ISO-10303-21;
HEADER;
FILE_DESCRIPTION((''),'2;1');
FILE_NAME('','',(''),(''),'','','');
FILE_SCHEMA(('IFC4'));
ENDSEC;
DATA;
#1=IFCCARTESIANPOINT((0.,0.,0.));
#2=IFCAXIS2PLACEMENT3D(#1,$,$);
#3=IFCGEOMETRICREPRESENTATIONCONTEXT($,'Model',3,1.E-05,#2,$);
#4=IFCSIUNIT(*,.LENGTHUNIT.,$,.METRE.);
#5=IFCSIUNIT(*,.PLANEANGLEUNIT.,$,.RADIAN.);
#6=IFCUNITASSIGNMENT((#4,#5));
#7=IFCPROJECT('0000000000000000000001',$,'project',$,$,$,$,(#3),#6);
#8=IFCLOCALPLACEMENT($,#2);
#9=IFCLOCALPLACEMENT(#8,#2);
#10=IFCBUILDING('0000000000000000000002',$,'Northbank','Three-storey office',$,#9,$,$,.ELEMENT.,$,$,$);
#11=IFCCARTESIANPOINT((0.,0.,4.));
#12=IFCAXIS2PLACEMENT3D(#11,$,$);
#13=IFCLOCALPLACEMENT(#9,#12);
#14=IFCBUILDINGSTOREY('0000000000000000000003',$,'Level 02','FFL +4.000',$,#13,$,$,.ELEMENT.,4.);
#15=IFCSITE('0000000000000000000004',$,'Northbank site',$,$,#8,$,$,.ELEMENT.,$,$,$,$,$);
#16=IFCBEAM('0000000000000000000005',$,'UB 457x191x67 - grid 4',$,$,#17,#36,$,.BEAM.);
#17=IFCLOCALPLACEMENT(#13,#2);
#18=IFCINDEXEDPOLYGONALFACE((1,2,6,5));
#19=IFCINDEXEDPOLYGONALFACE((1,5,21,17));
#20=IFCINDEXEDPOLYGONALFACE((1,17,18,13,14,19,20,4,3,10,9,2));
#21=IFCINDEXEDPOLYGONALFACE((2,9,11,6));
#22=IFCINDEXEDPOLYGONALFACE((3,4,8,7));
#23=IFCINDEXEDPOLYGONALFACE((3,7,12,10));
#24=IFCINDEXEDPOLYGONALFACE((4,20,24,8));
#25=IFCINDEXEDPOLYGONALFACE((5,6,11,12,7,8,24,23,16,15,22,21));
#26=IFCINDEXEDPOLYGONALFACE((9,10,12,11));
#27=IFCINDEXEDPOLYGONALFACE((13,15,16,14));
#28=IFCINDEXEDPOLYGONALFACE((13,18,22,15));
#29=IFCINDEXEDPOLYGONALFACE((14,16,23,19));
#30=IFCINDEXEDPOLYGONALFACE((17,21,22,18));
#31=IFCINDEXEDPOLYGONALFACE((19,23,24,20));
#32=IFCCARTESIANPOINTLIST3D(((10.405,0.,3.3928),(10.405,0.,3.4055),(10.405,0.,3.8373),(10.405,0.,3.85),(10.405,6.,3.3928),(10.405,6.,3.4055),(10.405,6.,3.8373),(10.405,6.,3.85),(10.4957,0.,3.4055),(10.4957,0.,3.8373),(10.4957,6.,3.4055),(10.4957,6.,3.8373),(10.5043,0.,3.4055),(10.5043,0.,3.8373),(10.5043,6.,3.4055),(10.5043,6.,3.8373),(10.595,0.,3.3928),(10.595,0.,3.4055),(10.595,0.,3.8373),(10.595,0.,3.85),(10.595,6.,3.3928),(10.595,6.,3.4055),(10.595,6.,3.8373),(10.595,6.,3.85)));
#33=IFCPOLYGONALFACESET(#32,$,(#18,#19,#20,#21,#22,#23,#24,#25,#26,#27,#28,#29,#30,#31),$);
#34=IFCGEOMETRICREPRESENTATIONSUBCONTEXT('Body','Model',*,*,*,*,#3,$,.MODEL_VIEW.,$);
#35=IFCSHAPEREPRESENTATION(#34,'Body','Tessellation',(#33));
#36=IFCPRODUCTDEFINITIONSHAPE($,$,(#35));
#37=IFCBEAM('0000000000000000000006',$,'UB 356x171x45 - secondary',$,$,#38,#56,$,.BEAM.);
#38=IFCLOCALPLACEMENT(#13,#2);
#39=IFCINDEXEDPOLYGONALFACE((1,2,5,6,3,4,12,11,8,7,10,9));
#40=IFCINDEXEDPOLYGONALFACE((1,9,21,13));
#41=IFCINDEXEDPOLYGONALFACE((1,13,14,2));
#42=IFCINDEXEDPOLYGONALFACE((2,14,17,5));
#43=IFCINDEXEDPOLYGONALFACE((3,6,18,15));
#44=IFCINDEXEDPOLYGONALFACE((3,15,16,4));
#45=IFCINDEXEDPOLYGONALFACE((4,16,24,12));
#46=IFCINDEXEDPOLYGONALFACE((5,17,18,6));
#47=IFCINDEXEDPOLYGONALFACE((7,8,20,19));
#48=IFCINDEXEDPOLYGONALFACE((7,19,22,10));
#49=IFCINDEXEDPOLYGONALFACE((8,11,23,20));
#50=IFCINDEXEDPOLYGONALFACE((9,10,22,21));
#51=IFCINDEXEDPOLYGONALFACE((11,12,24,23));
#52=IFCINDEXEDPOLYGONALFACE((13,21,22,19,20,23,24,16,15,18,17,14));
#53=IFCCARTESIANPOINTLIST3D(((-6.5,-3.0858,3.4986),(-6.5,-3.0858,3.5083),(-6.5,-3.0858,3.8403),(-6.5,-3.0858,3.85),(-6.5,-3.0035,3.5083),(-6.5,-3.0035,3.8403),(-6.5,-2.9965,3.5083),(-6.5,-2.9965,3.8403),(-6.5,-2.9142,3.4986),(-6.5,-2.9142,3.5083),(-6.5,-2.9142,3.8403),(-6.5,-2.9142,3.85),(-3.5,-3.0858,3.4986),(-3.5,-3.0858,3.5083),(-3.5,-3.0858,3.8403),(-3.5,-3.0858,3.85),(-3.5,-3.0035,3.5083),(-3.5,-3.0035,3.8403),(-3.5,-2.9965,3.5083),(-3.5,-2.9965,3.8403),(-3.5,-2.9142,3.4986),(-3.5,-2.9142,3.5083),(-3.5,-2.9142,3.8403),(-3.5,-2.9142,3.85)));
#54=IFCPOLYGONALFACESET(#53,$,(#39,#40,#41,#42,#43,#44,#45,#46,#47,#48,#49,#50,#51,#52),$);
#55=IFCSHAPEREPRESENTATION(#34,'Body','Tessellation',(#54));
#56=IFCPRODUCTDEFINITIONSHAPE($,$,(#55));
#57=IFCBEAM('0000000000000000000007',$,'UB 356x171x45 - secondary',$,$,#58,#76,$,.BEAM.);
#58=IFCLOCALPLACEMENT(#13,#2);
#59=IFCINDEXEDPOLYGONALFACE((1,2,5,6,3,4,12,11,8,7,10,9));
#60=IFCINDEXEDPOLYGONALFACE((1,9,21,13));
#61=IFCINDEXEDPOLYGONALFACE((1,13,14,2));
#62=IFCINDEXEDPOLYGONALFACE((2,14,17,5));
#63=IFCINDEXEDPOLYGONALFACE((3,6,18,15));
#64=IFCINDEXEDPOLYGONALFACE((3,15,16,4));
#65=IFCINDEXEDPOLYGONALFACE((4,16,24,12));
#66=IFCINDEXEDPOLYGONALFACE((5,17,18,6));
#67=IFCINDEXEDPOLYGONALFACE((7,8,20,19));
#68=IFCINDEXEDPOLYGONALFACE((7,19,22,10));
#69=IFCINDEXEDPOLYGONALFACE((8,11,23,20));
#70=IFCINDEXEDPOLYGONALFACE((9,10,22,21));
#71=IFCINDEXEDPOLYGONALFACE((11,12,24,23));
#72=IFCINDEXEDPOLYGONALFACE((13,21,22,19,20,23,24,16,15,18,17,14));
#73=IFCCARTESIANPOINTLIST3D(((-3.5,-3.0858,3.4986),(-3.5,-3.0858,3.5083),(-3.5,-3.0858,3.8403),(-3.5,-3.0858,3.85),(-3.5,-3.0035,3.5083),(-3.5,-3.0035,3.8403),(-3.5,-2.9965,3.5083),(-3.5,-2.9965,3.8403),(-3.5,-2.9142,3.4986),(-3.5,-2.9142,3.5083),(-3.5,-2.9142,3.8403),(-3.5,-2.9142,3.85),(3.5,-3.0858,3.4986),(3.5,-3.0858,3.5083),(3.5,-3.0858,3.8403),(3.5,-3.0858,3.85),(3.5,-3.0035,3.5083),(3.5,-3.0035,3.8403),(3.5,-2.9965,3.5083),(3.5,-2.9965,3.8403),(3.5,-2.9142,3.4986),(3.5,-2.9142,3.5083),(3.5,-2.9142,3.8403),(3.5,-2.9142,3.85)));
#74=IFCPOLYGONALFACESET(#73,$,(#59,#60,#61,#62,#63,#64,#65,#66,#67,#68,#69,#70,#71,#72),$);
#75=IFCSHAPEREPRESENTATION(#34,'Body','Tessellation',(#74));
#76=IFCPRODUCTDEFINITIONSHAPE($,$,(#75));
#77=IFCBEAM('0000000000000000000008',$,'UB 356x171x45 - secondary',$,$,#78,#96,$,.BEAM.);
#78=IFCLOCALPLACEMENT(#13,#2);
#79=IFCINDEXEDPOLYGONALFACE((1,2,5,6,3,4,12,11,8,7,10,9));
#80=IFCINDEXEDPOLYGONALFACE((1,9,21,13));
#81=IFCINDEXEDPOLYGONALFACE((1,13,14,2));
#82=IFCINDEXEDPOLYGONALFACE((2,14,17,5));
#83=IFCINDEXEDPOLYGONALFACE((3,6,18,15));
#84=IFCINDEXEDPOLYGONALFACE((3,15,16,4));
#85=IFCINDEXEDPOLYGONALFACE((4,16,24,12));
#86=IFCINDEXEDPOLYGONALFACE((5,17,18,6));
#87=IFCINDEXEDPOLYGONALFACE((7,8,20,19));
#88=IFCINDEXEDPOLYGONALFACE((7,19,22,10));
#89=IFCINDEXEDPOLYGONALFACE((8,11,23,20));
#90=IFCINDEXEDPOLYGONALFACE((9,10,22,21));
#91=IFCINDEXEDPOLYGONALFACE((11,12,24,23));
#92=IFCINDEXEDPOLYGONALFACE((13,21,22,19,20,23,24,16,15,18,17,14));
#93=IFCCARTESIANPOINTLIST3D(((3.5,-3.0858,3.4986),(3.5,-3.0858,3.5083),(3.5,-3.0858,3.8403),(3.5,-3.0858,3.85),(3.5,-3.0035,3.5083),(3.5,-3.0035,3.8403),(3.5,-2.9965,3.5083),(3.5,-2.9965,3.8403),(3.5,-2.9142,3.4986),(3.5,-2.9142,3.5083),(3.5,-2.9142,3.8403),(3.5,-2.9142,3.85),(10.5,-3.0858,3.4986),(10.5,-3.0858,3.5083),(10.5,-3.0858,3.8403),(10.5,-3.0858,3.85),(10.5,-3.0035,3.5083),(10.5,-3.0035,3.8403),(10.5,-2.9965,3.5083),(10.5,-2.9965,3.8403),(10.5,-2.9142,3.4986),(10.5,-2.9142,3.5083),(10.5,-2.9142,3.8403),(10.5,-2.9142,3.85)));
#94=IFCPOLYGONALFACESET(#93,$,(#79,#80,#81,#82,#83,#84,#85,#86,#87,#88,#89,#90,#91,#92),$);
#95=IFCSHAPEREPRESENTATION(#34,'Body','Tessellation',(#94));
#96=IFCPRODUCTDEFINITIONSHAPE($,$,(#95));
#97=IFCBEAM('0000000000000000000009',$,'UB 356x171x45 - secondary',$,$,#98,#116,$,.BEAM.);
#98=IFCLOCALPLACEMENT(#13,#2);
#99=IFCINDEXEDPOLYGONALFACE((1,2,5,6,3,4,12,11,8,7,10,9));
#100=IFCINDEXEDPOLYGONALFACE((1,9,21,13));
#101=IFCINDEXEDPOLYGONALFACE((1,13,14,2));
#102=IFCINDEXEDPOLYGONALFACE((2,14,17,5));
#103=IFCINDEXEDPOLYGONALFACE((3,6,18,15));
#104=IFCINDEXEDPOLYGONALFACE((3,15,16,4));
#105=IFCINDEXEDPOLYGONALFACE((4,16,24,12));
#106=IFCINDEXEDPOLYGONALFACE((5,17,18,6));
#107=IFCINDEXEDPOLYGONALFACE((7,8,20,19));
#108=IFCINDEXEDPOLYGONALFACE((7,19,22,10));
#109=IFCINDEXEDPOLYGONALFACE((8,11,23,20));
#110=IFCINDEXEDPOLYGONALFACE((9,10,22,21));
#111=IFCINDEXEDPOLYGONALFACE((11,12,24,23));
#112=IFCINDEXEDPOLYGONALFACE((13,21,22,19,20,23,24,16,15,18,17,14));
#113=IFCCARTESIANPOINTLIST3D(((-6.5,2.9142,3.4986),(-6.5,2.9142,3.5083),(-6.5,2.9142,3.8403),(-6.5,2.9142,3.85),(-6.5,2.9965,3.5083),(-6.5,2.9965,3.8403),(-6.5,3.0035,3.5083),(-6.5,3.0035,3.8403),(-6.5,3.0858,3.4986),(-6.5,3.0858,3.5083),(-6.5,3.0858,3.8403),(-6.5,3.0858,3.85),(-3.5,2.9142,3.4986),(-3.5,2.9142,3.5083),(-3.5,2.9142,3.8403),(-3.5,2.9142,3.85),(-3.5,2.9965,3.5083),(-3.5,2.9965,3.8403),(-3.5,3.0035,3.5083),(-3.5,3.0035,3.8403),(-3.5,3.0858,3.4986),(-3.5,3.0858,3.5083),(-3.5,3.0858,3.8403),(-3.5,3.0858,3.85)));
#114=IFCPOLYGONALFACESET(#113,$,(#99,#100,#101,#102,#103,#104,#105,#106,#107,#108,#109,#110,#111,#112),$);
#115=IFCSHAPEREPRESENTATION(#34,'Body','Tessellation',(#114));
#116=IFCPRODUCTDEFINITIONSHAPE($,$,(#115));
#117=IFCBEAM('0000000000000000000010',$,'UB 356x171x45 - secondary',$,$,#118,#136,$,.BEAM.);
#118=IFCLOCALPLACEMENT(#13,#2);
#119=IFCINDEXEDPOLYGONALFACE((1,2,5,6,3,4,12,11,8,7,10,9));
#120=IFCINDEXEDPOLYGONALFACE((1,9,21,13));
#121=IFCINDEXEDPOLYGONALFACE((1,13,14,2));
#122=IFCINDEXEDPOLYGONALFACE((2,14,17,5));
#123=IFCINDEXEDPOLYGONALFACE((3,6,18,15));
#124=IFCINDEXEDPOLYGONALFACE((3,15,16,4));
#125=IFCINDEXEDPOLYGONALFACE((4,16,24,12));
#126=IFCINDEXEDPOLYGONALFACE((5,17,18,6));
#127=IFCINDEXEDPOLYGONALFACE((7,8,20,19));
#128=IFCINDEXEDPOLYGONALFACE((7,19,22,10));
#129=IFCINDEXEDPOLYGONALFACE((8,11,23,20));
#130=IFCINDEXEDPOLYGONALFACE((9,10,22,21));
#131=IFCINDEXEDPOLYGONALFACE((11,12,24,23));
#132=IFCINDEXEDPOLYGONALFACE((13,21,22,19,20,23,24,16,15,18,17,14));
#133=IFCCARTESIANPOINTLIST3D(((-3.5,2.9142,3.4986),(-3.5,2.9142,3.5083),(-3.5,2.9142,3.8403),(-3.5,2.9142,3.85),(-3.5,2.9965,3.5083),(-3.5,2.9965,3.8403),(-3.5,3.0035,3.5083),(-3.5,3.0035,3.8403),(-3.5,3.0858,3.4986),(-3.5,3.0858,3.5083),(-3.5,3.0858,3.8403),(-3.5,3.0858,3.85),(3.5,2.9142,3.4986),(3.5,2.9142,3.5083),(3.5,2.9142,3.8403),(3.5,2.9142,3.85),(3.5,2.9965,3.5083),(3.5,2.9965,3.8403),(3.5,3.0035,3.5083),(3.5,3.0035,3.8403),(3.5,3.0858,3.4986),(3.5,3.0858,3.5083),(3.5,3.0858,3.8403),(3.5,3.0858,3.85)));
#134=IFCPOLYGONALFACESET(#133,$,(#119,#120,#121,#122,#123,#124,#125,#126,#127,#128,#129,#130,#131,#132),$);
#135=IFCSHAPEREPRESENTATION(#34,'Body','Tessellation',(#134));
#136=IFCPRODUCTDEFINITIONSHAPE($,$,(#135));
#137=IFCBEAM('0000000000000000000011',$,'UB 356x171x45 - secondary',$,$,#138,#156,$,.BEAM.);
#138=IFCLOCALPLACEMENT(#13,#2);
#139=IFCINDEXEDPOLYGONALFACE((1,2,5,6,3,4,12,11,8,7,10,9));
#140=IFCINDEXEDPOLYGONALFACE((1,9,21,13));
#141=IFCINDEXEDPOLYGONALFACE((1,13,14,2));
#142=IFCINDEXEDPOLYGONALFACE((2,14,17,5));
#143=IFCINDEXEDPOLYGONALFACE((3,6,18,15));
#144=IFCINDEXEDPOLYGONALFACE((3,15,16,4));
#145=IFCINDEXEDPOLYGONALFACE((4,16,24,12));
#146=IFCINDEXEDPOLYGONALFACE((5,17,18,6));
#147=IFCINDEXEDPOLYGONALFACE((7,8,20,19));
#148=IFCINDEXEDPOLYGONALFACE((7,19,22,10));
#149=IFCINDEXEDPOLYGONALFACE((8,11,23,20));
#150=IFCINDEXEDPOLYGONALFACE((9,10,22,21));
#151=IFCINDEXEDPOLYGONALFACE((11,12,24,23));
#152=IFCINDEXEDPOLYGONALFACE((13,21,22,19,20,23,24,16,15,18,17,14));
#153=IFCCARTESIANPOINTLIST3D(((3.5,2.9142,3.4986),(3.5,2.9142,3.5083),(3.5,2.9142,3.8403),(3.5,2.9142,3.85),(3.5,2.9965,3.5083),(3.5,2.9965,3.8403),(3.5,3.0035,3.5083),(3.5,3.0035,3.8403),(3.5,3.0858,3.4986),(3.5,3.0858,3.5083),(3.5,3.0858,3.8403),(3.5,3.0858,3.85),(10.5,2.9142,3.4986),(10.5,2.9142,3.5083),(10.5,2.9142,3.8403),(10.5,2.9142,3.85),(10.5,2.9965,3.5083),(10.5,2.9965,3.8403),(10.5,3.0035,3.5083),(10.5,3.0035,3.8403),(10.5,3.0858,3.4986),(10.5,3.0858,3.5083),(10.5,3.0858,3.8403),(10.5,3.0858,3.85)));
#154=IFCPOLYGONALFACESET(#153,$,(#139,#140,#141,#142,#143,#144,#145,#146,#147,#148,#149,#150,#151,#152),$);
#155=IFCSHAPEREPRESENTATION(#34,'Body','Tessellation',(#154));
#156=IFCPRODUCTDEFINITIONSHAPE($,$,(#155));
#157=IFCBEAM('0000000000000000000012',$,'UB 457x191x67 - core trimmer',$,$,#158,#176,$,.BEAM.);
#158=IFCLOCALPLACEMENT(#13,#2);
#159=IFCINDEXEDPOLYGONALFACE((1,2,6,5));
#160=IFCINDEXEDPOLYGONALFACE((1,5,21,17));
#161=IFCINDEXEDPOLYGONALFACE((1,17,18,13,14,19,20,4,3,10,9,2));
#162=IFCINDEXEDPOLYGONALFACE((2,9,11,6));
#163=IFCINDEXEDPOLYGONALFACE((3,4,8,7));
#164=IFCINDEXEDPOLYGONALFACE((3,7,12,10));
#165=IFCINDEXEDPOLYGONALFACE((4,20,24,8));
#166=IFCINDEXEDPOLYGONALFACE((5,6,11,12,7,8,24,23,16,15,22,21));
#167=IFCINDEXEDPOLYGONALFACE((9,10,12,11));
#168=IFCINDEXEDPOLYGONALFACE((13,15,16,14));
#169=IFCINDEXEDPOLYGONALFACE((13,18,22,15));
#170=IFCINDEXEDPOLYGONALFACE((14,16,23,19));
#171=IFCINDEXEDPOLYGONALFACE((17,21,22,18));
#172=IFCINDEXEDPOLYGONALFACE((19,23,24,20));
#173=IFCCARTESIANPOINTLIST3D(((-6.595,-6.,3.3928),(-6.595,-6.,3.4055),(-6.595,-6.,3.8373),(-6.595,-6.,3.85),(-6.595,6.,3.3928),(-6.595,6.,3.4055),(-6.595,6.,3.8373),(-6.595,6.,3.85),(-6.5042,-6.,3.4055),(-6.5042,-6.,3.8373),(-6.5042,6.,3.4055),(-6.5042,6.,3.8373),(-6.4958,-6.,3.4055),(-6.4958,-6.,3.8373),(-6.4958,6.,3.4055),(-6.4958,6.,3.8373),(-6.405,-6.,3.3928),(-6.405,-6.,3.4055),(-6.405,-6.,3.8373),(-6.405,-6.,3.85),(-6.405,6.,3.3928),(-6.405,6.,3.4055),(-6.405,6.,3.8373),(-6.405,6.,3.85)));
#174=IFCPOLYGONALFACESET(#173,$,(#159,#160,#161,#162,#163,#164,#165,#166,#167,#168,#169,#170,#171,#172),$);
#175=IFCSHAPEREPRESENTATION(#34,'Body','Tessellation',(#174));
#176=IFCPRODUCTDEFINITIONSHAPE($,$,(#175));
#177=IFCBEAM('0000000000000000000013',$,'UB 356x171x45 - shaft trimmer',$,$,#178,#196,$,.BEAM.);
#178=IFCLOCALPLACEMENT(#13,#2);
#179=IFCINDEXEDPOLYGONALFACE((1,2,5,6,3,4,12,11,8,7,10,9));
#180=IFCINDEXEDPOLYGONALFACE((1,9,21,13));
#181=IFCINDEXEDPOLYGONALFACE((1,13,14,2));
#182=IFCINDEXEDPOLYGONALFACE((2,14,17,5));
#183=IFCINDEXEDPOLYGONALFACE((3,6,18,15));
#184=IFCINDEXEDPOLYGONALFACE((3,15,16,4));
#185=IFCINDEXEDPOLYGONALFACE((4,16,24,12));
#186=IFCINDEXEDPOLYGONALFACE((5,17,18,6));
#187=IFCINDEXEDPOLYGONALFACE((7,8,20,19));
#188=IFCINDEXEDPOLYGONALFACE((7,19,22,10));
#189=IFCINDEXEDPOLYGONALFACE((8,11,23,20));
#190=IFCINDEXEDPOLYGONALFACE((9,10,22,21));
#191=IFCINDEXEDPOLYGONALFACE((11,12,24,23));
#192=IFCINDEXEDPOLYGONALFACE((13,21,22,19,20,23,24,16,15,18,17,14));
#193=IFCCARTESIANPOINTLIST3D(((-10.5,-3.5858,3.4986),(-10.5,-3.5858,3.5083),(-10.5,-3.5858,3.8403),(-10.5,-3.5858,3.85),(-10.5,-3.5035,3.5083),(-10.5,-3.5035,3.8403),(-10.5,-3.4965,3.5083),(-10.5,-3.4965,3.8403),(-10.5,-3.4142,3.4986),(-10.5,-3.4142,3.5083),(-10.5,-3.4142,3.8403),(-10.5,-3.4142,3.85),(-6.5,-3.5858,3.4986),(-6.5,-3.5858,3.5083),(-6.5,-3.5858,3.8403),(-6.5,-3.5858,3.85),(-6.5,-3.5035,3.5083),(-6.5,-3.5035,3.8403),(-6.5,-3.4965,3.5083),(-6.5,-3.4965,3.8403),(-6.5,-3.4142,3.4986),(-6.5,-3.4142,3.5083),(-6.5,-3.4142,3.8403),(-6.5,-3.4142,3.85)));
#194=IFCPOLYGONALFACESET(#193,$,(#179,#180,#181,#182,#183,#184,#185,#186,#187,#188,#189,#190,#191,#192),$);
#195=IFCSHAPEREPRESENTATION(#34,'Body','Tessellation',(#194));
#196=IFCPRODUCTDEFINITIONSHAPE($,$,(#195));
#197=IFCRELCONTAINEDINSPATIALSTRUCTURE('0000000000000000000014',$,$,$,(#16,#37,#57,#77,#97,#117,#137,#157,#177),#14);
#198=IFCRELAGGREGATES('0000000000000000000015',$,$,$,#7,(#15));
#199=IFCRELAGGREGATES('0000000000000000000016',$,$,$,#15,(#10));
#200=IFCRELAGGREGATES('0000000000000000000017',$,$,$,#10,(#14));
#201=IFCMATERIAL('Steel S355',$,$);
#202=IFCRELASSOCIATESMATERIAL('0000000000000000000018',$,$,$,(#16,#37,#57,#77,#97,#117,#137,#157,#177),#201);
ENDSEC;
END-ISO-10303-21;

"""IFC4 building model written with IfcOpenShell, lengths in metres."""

from ifc_helpers import new_model, si_unit, frame, origin, place, context, subcontext, project, spatial, i_section, extrude, material, element, save


model = new_model("IFC4")

# Units and contexts
model_context = context("Model", 3, precision=1e-05, world=origin())
body_context = subcontext(model_context, "Body", "Model", "MODEL_VIEW")
ifc_project = project(units=[si_unit("LENGTHUNIT", "METRE"), si_unit("PLANEANGLEUNIT", "RADIAN")], contexts=[model_context])

# Site, building, storey
site_placement = place(None, origin())
site = spatial("IfcSite", under=ifc_project, at=site_placement, Name="Northbank site", CompositionType="ELEMENT")
building_placement = place(site_placement, origin())
building = spatial("IfcBuilding", under=site, at=building_placement, Name="Northbank", Description="Three-storey office", CompositionType="ELEMENT")
storey_placement = place(building_placement, frame((0.0, 0.0, 4.0)))
storey = spatial("IfcBuildingStorey", under=building, at=storey_placement, Name="Level 02", Description="FFL +4.000", CompositionType="ELEMENT", Elevation=4.0)

# Beams
ifc_material_1 = material(Name="Steel S355")
beam_1_placement = place(storey_placement, frame((0.0, 0.0, -4.0)))
element("IfcBeam", 1, at=beam_1_placement, inside=storey, material=ifc_material_1, Name="UB 457x191x67 - grid 4", PredefinedType="BEAM", context=body_context, shape_type="SweptSolid", body=[
    extrude(i_section(OverallWidth=0.1899, OverallDepth=0.4572, WebThickness=0.0085, FlangeThickness=0.0127), frame((10.5, 0.0, 7.6214), z_axis=(0.0, 1.0, 0.0), x_axis=(-1.0, 0.0, 0.0)), (0.0, 0.0, 1.0), 6.0),
])
beam_2_placement = place(storey_placement, frame((0.0, 0.0, -4.0)))
element("IfcBeam", 2, at=beam_2_placement, inside=storey, material=ifc_material_1, Name="UB 356x171x45 - secondary", PredefinedType="BEAM", context=body_context, shape_type="SweptSolid", body=[
    extrude(i_section(OverallWidth=0.1715, OverallDepth=0.3514, WebThickness=0.007, FlangeThickness=0.0097), frame((-6.5, -3.0, 7.6743), z_axis=(1.0, 0.0, 0.0), x_axis=(0.0, 1.0, 0.0)), (0.0, 0.0, 1.0), 3.0),
])
beam_3_placement = place(storey_placement, frame((0.0, 0.0, -4.0)))
element("IfcBeam", 3, at=beam_3_placement, inside=storey, material=ifc_material_1, Name="UB 356x171x45 - secondary", PredefinedType="BEAM", context=body_context, shape_type="SweptSolid", body=[
    extrude(i_section(OverallWidth=0.1715, OverallDepth=0.3514, WebThickness=0.007, FlangeThickness=0.0097), frame((-3.5, -3.0, 7.6743), z_axis=(1.0, 0.0, 0.0), x_axis=(0.0, 1.0, 0.0)), (0.0, 0.0, 1.0), 7.0),
])
beam_4_placement = place(storey_placement, frame((0.0, 0.0, -4.0)))
element("IfcBeam", 4, at=beam_4_placement, inside=storey, material=ifc_material_1, Name="UB 356x171x45 - secondary", PredefinedType="BEAM", context=body_context, shape_type="SweptSolid", body=[
    extrude(i_section(OverallWidth=0.1715, OverallDepth=0.3514, WebThickness=0.007, FlangeThickness=0.0097), frame((3.5, -3.0, 7.6743), z_axis=(1.0, 0.0, 0.0), x_axis=(0.0, 1.0, 0.0)), (0.0, 0.0, 1.0), 7.0),
])
beam_5_placement = place(storey_placement, frame((0.0, 0.0, -4.0)))
element("IfcBeam", 5, at=beam_5_placement, inside=storey, material=ifc_material_1, Name="UB 356x171x45 - secondary", PredefinedType="BEAM", context=body_context, shape_type="SweptSolid", body=[
    extrude(i_section(OverallWidth=0.1715, OverallDepth=0.3514, WebThickness=0.007, FlangeThickness=0.0097), frame((-6.5, 3.0, 7.6743), z_axis=(1.0, 0.0, 0.0), x_axis=(0.0, 1.0, 0.0)), (0.0, 0.0, 1.0), 3.0),
])
beam_6_placement = place(storey_placement, frame((0.0, 0.0, -4.0)))
element("IfcBeam", 6, at=beam_6_placement, inside=storey, material=ifc_material_1, Name="UB 356x171x45 - secondary", PredefinedType="BEAM", context=body_context, shape_type="SweptSolid", body=[
    extrude(i_section(OverallWidth=0.1715, OverallDepth=0.3514, WebThickness=0.007, FlangeThickness=0.0097), frame((-3.5, 3.0, 7.6743), z_axis=(1.0, 0.0, 0.0), x_axis=(0.0, 1.0, 0.0)), (0.0, 0.0, 1.0), 7.0),
])
beam_7_placement = place(storey_placement, frame((0.0, 0.0, -4.0)))
element("IfcBeam", 7, at=beam_7_placement, inside=storey, material=ifc_material_1, Name="UB 356x171x45 - secondary", PredefinedType="BEAM", context=body_context, shape_type="SweptSolid", body=[
    extrude(i_section(OverallWidth=0.1715, OverallDepth=0.3514, WebThickness=0.007, FlangeThickness=0.0097), frame((3.5, 3.0, 7.6743), z_axis=(1.0, 0.0, 0.0), x_axis=(0.0, 1.0, 0.0)), (0.0, 0.0, 1.0), 7.0),
])
beam_8_placement = place(storey_placement, frame((0.0, 0.0, -4.0)))
element("IfcBeam", 8, at=beam_8_placement, inside=storey, material=ifc_material_1, Name="UB 457x191x67 - core trimmer", PredefinedType="BEAM", context=body_context, shape_type="SweptSolid", body=[
    extrude(i_section(OverallWidth=0.1899, OverallDepth=0.4572, WebThickness=0.0085, FlangeThickness=0.0127), frame((-6.5, -6.0, 7.6214), z_axis=(0.0, 1.0, 0.0), x_axis=(-1.0, 0.0, 0.0)), (0.0, 0.0, 1.0), 12.0),
])
beam_9_placement = place(storey_placement, frame((0.0, 0.0, -4.0)))
element("IfcBeam", 9, at=beam_9_placement, inside=storey, material=ifc_material_1, Name="UB 356x171x45 - shaft trimmer", PredefinedType="BEAM", context=body_context, shape_type="SweptSolid", body=[
    extrude(i_section(OverallWidth=0.1715, OverallDepth=0.3514, WebThickness=0.007, FlangeThickness=0.0097), frame((-10.5, -3.5, 7.6743), z_axis=(1.0, 0.0, 0.0), x_axis=(0.0, 1.0, 0.0)), (0.0, 0.0, 1.0), 4.0),
])

save(model, "model.ifc")
